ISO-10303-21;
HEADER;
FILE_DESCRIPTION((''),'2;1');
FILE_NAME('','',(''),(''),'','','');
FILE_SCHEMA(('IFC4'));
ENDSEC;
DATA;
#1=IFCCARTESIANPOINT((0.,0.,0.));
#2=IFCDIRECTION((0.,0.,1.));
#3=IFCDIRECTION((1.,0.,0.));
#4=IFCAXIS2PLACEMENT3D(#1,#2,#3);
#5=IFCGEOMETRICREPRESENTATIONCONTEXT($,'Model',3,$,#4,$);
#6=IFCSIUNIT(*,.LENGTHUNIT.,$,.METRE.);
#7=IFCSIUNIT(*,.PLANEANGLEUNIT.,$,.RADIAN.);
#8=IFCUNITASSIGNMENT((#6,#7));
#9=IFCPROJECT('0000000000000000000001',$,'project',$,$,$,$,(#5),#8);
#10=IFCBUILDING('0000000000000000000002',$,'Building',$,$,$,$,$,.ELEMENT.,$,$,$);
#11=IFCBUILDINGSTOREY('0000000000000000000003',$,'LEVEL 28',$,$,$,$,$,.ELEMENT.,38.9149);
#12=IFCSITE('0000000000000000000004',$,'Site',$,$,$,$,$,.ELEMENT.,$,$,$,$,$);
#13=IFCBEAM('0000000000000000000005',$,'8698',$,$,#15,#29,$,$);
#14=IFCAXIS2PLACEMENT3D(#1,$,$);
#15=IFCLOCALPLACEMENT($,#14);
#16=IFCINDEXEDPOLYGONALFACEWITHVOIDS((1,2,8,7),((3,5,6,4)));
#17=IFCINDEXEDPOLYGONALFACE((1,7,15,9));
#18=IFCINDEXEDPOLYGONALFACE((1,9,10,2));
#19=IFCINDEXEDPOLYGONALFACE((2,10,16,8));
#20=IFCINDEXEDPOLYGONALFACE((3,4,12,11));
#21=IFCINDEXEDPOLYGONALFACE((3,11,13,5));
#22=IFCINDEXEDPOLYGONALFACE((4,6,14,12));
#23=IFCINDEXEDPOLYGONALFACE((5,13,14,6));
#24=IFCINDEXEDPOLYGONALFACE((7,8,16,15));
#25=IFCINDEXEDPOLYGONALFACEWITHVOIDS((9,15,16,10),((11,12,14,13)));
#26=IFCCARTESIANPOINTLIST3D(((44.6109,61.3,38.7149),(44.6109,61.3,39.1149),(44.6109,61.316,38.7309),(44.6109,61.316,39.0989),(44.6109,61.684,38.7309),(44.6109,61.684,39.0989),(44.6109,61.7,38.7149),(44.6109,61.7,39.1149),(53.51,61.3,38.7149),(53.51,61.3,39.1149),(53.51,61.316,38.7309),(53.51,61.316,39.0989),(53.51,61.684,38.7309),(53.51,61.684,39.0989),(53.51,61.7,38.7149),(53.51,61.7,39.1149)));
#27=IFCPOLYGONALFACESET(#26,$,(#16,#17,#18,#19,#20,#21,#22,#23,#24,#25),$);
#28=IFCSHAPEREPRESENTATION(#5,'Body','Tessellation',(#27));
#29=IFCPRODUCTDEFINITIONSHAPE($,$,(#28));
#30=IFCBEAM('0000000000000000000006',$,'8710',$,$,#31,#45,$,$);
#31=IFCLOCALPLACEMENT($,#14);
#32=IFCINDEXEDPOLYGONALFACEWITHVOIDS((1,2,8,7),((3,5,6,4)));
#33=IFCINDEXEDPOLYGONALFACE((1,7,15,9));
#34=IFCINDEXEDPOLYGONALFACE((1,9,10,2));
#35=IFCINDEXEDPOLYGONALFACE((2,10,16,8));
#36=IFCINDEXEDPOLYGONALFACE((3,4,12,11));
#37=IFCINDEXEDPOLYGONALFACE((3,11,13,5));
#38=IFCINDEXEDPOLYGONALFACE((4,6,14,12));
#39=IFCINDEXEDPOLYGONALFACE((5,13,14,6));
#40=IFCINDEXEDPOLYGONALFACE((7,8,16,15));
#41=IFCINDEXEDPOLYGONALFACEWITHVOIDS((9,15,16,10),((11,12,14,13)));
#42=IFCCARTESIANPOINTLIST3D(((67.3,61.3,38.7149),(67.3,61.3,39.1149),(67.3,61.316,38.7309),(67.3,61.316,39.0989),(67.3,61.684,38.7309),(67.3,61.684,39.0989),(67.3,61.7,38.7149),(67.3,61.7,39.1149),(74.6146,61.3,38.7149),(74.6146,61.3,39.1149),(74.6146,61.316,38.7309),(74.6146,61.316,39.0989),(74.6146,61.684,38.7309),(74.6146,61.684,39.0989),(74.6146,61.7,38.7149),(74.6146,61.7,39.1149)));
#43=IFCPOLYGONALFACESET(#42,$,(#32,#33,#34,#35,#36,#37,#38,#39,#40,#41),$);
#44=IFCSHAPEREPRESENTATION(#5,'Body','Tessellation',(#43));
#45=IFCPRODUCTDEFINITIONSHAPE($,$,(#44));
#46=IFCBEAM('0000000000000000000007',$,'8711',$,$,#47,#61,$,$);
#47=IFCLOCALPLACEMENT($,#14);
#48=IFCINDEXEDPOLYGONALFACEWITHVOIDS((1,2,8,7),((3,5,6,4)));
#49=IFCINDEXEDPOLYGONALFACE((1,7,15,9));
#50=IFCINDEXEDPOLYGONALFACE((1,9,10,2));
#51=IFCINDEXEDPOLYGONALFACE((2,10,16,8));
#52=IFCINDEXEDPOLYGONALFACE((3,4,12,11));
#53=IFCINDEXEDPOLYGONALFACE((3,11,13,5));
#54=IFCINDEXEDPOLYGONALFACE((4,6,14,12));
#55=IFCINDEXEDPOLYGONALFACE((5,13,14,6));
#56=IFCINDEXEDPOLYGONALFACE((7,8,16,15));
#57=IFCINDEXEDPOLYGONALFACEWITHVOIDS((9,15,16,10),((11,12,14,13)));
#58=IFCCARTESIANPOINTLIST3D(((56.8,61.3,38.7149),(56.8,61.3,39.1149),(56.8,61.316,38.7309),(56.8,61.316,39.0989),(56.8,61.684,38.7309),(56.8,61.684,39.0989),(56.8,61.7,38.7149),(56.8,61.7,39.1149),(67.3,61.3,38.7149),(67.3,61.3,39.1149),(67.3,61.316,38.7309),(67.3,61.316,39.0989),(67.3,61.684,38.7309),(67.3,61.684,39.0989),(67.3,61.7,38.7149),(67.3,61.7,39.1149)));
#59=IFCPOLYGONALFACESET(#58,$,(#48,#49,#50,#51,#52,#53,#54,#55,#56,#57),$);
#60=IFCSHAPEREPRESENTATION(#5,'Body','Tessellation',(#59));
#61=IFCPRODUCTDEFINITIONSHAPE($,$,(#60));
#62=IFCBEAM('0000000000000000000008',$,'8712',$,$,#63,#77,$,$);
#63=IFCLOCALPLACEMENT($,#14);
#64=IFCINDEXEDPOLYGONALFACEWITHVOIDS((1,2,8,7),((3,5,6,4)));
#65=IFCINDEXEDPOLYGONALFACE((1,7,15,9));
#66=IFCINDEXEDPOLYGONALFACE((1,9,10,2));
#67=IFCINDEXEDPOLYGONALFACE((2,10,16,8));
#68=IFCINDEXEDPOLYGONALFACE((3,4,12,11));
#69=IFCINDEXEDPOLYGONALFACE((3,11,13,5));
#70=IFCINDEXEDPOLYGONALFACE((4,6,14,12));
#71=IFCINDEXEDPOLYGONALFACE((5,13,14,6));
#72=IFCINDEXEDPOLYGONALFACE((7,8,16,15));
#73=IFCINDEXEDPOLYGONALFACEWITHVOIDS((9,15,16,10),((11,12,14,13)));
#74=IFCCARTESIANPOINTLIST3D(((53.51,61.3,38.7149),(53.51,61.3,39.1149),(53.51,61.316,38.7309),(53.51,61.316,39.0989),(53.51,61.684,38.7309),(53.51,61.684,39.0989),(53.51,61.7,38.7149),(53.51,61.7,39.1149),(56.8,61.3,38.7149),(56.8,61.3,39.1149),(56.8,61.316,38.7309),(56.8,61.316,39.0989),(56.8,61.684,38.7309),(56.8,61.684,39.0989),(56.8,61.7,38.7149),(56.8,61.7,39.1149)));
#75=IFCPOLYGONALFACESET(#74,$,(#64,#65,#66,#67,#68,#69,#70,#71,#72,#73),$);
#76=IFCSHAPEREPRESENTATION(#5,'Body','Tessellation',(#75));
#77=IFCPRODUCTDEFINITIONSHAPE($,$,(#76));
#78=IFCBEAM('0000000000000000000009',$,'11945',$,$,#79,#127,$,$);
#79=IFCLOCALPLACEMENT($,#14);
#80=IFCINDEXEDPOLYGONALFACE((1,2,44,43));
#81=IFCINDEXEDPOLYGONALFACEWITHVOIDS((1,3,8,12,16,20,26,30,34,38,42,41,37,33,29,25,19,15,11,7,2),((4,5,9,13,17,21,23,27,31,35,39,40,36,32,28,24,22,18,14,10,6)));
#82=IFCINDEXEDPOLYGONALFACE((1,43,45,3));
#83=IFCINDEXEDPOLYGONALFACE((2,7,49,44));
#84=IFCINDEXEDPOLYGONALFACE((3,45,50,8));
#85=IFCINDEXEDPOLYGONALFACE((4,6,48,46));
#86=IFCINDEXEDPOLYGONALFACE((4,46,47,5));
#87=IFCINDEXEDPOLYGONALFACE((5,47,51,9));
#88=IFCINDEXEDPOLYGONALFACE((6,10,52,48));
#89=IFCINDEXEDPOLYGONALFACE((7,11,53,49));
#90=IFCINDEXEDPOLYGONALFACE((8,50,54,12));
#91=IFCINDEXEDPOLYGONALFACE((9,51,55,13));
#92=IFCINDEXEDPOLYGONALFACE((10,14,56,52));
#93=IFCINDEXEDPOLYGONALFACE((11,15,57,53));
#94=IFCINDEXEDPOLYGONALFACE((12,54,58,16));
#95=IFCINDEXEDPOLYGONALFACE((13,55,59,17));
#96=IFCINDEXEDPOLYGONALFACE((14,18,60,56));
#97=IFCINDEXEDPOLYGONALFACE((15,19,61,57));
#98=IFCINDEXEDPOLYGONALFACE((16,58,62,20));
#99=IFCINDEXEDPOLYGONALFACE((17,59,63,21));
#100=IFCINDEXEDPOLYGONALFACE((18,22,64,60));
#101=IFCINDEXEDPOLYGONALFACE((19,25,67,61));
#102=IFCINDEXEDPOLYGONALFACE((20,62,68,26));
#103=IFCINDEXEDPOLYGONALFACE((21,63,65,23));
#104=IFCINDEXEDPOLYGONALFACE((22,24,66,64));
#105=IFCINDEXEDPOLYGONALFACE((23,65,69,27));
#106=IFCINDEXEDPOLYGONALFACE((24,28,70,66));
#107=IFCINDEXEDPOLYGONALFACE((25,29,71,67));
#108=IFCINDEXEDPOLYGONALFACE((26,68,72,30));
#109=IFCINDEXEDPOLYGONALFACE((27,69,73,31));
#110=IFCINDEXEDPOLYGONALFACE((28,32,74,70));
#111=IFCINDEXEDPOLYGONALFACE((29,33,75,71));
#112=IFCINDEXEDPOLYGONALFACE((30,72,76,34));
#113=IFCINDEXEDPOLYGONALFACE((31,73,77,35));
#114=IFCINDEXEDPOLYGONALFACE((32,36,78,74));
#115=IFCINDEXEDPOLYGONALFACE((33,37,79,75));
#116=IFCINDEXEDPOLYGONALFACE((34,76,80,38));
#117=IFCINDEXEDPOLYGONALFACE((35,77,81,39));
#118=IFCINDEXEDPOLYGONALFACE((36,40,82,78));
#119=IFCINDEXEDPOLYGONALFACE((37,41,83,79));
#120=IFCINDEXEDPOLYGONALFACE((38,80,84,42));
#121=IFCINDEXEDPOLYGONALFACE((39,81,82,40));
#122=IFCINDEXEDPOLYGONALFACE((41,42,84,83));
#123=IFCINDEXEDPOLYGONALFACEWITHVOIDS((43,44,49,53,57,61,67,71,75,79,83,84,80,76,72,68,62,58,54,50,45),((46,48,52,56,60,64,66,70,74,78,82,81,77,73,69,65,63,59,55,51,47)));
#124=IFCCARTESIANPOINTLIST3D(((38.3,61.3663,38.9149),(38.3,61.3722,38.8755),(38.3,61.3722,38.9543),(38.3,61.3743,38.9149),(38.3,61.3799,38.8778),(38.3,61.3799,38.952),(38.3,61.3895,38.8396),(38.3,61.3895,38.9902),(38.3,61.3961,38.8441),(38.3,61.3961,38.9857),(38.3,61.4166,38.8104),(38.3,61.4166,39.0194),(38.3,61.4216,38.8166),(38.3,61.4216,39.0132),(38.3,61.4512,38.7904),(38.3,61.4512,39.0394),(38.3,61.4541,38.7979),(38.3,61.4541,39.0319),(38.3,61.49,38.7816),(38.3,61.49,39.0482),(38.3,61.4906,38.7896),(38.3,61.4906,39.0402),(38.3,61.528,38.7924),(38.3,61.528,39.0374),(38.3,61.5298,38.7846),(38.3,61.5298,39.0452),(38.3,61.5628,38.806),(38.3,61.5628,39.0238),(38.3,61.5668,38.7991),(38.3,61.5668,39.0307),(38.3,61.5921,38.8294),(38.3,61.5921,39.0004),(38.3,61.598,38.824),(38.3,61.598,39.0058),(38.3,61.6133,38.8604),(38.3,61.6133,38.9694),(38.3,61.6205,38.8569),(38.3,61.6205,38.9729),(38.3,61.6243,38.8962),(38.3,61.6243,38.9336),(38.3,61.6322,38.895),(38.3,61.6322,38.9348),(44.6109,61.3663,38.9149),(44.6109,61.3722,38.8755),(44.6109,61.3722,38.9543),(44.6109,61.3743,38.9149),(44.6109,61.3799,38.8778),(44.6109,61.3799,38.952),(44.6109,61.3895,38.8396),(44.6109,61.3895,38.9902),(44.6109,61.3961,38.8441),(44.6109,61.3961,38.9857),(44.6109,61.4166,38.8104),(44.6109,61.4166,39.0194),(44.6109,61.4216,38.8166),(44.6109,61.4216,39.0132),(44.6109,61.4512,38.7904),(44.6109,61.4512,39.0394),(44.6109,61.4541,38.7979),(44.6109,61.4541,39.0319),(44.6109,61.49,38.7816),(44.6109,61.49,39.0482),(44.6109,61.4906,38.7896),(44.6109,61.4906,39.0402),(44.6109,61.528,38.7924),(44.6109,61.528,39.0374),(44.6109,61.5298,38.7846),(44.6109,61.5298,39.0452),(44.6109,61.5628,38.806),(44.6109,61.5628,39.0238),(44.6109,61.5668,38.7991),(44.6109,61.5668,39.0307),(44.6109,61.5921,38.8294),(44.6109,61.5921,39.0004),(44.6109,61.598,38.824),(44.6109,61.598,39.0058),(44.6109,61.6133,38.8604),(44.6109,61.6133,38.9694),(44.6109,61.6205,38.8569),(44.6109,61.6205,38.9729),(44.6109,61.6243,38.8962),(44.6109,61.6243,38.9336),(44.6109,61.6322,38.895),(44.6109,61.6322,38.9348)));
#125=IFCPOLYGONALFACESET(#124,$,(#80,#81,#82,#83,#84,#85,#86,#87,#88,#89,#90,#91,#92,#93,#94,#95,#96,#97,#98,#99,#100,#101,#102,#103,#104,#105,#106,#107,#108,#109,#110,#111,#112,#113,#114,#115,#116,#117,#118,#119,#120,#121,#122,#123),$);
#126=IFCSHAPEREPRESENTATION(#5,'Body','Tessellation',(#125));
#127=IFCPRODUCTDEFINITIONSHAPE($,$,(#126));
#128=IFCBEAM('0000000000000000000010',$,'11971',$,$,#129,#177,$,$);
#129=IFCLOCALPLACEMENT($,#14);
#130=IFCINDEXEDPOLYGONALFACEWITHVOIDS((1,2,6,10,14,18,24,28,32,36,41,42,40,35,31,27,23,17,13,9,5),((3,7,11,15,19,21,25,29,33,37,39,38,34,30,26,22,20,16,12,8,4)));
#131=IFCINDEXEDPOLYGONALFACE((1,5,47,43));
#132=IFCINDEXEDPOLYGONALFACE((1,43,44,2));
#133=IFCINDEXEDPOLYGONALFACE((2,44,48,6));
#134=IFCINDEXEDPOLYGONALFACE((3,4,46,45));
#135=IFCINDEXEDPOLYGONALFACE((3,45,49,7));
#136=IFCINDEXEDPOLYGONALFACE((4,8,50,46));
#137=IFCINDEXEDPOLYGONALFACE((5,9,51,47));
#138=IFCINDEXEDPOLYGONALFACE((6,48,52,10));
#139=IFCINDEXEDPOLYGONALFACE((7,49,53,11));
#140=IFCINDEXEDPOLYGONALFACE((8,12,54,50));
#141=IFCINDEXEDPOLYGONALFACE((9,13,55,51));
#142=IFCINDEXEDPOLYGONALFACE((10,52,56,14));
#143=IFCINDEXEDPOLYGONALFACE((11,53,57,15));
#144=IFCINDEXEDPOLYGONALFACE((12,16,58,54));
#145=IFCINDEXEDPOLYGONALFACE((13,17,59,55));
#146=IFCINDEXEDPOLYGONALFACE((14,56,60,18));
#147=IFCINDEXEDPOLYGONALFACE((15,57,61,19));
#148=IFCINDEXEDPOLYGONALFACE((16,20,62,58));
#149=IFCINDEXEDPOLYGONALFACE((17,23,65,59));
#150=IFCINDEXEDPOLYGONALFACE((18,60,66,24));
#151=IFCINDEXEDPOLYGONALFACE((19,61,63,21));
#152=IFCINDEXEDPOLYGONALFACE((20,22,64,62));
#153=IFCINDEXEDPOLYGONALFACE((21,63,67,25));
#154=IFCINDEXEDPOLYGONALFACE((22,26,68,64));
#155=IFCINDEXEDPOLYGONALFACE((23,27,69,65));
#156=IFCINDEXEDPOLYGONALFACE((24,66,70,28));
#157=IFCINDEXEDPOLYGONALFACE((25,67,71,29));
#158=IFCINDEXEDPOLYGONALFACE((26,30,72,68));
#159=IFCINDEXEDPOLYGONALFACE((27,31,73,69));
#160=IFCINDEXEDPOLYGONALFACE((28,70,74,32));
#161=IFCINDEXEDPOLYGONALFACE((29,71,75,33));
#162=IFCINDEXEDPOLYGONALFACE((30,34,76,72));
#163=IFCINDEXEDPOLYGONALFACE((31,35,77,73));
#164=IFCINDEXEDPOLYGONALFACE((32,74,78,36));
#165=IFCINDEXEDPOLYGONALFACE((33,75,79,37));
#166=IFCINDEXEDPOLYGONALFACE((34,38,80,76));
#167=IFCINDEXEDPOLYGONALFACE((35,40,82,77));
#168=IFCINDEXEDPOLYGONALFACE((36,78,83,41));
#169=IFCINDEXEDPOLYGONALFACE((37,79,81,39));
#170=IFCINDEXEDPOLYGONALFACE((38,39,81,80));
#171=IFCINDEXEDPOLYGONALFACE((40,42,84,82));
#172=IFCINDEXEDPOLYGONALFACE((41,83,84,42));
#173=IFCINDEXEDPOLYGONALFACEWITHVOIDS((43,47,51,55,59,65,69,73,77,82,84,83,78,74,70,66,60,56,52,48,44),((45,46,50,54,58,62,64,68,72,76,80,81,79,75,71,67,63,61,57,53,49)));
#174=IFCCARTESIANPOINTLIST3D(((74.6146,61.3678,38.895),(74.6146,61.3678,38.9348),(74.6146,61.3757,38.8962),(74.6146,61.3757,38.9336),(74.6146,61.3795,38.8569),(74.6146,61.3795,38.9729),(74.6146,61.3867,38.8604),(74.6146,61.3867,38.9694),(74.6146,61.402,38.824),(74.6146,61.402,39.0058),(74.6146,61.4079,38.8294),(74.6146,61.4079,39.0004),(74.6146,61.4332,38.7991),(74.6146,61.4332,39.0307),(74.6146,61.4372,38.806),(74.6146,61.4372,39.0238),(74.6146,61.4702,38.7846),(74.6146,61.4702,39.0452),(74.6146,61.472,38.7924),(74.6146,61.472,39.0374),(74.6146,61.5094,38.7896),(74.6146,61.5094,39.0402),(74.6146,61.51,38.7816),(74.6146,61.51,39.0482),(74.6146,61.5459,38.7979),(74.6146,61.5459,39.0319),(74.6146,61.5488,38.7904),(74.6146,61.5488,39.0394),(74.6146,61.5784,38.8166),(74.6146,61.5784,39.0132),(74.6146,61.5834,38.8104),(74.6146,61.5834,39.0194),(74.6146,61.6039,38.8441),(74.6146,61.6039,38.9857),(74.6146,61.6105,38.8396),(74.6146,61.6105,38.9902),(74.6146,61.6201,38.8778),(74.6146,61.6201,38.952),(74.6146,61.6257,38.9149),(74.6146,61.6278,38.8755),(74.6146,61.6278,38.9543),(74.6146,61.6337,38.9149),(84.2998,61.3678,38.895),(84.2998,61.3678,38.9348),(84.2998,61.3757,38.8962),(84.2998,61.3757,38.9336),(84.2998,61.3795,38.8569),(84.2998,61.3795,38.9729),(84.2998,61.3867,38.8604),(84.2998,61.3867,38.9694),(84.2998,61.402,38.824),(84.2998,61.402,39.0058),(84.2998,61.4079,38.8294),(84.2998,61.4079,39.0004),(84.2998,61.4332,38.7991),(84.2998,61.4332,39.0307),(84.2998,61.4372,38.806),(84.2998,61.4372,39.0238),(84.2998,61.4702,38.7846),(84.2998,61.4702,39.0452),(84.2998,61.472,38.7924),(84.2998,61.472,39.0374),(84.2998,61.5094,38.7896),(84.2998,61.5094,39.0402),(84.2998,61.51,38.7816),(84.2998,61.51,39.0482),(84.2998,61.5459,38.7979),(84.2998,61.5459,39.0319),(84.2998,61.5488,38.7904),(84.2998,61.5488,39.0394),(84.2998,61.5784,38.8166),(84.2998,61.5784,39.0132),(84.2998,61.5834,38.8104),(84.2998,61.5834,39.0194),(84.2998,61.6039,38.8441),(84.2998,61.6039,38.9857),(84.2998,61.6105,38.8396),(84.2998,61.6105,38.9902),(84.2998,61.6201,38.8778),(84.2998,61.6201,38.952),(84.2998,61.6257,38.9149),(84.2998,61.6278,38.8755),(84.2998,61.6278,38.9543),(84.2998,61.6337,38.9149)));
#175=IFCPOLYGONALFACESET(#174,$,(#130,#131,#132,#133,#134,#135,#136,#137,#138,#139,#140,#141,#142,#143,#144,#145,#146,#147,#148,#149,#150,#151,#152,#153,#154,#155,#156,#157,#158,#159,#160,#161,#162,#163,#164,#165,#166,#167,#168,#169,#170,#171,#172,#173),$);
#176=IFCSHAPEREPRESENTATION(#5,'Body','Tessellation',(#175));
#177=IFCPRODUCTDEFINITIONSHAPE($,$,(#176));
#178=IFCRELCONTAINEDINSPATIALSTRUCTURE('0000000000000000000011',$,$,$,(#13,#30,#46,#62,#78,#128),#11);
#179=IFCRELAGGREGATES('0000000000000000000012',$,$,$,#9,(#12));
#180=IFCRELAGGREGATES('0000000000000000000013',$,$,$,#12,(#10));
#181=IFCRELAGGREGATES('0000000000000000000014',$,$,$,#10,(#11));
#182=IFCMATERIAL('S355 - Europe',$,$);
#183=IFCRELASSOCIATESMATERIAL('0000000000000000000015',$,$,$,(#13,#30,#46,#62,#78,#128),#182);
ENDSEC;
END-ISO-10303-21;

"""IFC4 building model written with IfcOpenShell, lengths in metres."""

from ifc_helpers import new_model, si_unit, frame, origin_with_axes, origin_2d_with_axis, place, context, project, spatial, hollow_rectangle, hollow_circle, extrude, material, material_profile, profile_set, profile_usage, element, save


model = new_model("IFC4")

# Units and contexts
model_context = context("Model", 3, world=origin_with_axes())
ifc_project = project(units=[si_unit("LENGTHUNIT", "METRE"), si_unit("PLANEANGLEUNIT", "RADIAN")], contexts=[model_context])

# Site, building, storey
site = spatial("IfcSite", under=ifc_project, Name="Site", CompositionType="ELEMENT")
building = spatial("IfcBuilding", under=site, Name="Building", CompositionType="ELEMENT")
storey = spatial("IfcBuildingStorey", under=building, Name="LEVEL 28", CompositionType="ELEMENT", Elevation=38.9149)

# Beams
ifc_material = material(Name="S355 - Europe")
ifc_material_profile_1 = material_profile(ifc_material, hollow_rectangle(XDim=0.4, YDim=0.4, WallThickness=0.016, at=origin_2d_with_axis()))
ifc_profile_set_1 = profile_set([ifc_material_profile_1])
ifc_profile_usage_1 = profile_usage(ifc_profile_set_1, cardinal=10)
beam_1_placement = place(None, frame((44.6109, 61.5, 38.9149), z_axis=(1.0, 0.0, 0.0), x_axis=(0.0, 1.0, 0.0)))
element("IfcBeam", 1, at=beam_1_placement, inside=storey, material=ifc_profile_usage_1, Name="8698", context=model_context, shape_type="SweptSolid", body=[
    extrude(hollow_rectangle(XDim=0.4, YDim=0.4, WallThickness=0.016, at=origin_2d_with_axis()), origin_with_axes(), (0.0, 0.0, 1.0), 8.8991),
])
ifc_material_profile_2 = material_profile(ifc_material, hollow_rectangle(XDim=0.4, YDim=0.4, WallThickness=0.016, at=origin_2d_with_axis()))
ifc_profile_set_2 = profile_set([ifc_material_profile_2])
ifc_profile_usage_2 = profile_usage(ifc_profile_set_2, cardinal=10)
beam_2_placement = place(None, frame((67.3, 61.5, 38.9149), z_axis=(1.0, 0.0, 0.0), x_axis=(0.0, 1.0, 0.0)))
element("IfcBeam", 2, at=beam_2_placement, inside=storey, material=ifc_profile_usage_2, Name="8710", context=model_context, shape_type="SweptSolid", body=[
    extrude(hollow_rectangle(XDim=0.4, YDim=0.4, WallThickness=0.016, at=origin_2d_with_axis()), origin_with_axes(), (0.0, 0.0, 1.0), 7.3146),
])
ifc_material_profile_3 = material_profile(ifc_material, hollow_rectangle(XDim=0.4, YDim=0.4, WallThickness=0.016, at=origin_2d_with_axis()))
ifc_profile_set_3 = profile_set([ifc_material_profile_3])
ifc_profile_usage_3 = profile_usage(ifc_profile_set_3, cardinal=10)
beam_3_placement = place(None, frame((56.8, 61.5, 38.9149), z_axis=(1.0, 0.0, 0.0), x_axis=(0.0, 1.0, 0.0)))
element("IfcBeam", 3, at=beam_3_placement, inside=storey, material=ifc_profile_usage_3, Name="8711", context=model_context, shape_type="SweptSolid", body=[
    extrude(hollow_rectangle(XDim=0.4, YDim=0.4, WallThickness=0.016, at=origin_2d_with_axis()), origin_with_axes(), (0.0, 0.0, 1.0), 10.5),
])
ifc_material_profile_4 = material_profile(ifc_material, hollow_rectangle(XDim=0.4, YDim=0.4, WallThickness=0.016, at=origin_2d_with_axis()))
ifc_profile_set_4 = profile_set([ifc_material_profile_4])
ifc_profile_usage_4 = profile_usage(ifc_profile_set_4, cardinal=10)
beam_4_placement = place(None, frame((53.51, 61.5, 38.9149), z_axis=(1.0, 0.0, 0.0), x_axis=(0.0, 1.0, 0.0)))
element("IfcBeam", 4, at=beam_4_placement, inside=storey, material=ifc_profile_usage_4, Name="8712", context=model_context, shape_type="SweptSolid", body=[
    extrude(hollow_rectangle(XDim=0.4, YDim=0.4, WallThickness=0.016, at=origin_2d_with_axis()), origin_with_axes(), (0.0, 0.0, 1.0), 3.29),
])
ifc_material_profile_5 = material_profile(ifc_material, hollow_circle(Radius=0.1337, WallThickness=0.008, at=origin_2d_with_axis()))
ifc_profile_set_5 = profile_set([ifc_material_profile_5])
ifc_profile_usage_5 = profile_usage(ifc_profile_set_5, cardinal=10)
beam_5_placement = place(None, frame((44.6109, 61.5, 38.9149), z_axis=(-1.0, 0.0, 0.0), x_axis=(0.0, -1.0, 0.0)))
element("IfcBeam", 5, at=beam_5_placement, inside=storey, material=ifc_profile_usage_5, Name="11945", context=model_context, shape_type="SweptSolid", body=[
    extrude(hollow_circle(Radius=0.1337, WallThickness=0.008, at=origin_2d_with_axis()), origin_with_axes(), (0.0, 0.0, 1.0), 6.3109),
])
ifc_material_profile_6 = material_profile(ifc_material, hollow_circle(Radius=0.1337, WallThickness=0.008, at=origin_2d_with_axis()))
ifc_profile_set_6 = profile_set([ifc_material_profile_6])
ifc_profile_usage_6 = profile_usage(ifc_profile_set_6, cardinal=10)
beam_6_placement = place(None, frame((74.6146, 61.5, 38.9149), z_axis=(1.0, 0.0, 0.0), x_axis=(0.0, 1.0, 0.0)))
element("IfcBeam", 6, at=beam_6_placement, inside=storey, material=ifc_profile_usage_6, Name="11971", context=model_context, shape_type="SweptSolid", body=[
    extrude(hollow_circle(Radius=0.1337, WallThickness=0.008, at=origin_2d_with_axis()), origin_with_axes(), (0.0, 0.0, 1.0), 9.6852),
])

save(model, "model.ifc")
